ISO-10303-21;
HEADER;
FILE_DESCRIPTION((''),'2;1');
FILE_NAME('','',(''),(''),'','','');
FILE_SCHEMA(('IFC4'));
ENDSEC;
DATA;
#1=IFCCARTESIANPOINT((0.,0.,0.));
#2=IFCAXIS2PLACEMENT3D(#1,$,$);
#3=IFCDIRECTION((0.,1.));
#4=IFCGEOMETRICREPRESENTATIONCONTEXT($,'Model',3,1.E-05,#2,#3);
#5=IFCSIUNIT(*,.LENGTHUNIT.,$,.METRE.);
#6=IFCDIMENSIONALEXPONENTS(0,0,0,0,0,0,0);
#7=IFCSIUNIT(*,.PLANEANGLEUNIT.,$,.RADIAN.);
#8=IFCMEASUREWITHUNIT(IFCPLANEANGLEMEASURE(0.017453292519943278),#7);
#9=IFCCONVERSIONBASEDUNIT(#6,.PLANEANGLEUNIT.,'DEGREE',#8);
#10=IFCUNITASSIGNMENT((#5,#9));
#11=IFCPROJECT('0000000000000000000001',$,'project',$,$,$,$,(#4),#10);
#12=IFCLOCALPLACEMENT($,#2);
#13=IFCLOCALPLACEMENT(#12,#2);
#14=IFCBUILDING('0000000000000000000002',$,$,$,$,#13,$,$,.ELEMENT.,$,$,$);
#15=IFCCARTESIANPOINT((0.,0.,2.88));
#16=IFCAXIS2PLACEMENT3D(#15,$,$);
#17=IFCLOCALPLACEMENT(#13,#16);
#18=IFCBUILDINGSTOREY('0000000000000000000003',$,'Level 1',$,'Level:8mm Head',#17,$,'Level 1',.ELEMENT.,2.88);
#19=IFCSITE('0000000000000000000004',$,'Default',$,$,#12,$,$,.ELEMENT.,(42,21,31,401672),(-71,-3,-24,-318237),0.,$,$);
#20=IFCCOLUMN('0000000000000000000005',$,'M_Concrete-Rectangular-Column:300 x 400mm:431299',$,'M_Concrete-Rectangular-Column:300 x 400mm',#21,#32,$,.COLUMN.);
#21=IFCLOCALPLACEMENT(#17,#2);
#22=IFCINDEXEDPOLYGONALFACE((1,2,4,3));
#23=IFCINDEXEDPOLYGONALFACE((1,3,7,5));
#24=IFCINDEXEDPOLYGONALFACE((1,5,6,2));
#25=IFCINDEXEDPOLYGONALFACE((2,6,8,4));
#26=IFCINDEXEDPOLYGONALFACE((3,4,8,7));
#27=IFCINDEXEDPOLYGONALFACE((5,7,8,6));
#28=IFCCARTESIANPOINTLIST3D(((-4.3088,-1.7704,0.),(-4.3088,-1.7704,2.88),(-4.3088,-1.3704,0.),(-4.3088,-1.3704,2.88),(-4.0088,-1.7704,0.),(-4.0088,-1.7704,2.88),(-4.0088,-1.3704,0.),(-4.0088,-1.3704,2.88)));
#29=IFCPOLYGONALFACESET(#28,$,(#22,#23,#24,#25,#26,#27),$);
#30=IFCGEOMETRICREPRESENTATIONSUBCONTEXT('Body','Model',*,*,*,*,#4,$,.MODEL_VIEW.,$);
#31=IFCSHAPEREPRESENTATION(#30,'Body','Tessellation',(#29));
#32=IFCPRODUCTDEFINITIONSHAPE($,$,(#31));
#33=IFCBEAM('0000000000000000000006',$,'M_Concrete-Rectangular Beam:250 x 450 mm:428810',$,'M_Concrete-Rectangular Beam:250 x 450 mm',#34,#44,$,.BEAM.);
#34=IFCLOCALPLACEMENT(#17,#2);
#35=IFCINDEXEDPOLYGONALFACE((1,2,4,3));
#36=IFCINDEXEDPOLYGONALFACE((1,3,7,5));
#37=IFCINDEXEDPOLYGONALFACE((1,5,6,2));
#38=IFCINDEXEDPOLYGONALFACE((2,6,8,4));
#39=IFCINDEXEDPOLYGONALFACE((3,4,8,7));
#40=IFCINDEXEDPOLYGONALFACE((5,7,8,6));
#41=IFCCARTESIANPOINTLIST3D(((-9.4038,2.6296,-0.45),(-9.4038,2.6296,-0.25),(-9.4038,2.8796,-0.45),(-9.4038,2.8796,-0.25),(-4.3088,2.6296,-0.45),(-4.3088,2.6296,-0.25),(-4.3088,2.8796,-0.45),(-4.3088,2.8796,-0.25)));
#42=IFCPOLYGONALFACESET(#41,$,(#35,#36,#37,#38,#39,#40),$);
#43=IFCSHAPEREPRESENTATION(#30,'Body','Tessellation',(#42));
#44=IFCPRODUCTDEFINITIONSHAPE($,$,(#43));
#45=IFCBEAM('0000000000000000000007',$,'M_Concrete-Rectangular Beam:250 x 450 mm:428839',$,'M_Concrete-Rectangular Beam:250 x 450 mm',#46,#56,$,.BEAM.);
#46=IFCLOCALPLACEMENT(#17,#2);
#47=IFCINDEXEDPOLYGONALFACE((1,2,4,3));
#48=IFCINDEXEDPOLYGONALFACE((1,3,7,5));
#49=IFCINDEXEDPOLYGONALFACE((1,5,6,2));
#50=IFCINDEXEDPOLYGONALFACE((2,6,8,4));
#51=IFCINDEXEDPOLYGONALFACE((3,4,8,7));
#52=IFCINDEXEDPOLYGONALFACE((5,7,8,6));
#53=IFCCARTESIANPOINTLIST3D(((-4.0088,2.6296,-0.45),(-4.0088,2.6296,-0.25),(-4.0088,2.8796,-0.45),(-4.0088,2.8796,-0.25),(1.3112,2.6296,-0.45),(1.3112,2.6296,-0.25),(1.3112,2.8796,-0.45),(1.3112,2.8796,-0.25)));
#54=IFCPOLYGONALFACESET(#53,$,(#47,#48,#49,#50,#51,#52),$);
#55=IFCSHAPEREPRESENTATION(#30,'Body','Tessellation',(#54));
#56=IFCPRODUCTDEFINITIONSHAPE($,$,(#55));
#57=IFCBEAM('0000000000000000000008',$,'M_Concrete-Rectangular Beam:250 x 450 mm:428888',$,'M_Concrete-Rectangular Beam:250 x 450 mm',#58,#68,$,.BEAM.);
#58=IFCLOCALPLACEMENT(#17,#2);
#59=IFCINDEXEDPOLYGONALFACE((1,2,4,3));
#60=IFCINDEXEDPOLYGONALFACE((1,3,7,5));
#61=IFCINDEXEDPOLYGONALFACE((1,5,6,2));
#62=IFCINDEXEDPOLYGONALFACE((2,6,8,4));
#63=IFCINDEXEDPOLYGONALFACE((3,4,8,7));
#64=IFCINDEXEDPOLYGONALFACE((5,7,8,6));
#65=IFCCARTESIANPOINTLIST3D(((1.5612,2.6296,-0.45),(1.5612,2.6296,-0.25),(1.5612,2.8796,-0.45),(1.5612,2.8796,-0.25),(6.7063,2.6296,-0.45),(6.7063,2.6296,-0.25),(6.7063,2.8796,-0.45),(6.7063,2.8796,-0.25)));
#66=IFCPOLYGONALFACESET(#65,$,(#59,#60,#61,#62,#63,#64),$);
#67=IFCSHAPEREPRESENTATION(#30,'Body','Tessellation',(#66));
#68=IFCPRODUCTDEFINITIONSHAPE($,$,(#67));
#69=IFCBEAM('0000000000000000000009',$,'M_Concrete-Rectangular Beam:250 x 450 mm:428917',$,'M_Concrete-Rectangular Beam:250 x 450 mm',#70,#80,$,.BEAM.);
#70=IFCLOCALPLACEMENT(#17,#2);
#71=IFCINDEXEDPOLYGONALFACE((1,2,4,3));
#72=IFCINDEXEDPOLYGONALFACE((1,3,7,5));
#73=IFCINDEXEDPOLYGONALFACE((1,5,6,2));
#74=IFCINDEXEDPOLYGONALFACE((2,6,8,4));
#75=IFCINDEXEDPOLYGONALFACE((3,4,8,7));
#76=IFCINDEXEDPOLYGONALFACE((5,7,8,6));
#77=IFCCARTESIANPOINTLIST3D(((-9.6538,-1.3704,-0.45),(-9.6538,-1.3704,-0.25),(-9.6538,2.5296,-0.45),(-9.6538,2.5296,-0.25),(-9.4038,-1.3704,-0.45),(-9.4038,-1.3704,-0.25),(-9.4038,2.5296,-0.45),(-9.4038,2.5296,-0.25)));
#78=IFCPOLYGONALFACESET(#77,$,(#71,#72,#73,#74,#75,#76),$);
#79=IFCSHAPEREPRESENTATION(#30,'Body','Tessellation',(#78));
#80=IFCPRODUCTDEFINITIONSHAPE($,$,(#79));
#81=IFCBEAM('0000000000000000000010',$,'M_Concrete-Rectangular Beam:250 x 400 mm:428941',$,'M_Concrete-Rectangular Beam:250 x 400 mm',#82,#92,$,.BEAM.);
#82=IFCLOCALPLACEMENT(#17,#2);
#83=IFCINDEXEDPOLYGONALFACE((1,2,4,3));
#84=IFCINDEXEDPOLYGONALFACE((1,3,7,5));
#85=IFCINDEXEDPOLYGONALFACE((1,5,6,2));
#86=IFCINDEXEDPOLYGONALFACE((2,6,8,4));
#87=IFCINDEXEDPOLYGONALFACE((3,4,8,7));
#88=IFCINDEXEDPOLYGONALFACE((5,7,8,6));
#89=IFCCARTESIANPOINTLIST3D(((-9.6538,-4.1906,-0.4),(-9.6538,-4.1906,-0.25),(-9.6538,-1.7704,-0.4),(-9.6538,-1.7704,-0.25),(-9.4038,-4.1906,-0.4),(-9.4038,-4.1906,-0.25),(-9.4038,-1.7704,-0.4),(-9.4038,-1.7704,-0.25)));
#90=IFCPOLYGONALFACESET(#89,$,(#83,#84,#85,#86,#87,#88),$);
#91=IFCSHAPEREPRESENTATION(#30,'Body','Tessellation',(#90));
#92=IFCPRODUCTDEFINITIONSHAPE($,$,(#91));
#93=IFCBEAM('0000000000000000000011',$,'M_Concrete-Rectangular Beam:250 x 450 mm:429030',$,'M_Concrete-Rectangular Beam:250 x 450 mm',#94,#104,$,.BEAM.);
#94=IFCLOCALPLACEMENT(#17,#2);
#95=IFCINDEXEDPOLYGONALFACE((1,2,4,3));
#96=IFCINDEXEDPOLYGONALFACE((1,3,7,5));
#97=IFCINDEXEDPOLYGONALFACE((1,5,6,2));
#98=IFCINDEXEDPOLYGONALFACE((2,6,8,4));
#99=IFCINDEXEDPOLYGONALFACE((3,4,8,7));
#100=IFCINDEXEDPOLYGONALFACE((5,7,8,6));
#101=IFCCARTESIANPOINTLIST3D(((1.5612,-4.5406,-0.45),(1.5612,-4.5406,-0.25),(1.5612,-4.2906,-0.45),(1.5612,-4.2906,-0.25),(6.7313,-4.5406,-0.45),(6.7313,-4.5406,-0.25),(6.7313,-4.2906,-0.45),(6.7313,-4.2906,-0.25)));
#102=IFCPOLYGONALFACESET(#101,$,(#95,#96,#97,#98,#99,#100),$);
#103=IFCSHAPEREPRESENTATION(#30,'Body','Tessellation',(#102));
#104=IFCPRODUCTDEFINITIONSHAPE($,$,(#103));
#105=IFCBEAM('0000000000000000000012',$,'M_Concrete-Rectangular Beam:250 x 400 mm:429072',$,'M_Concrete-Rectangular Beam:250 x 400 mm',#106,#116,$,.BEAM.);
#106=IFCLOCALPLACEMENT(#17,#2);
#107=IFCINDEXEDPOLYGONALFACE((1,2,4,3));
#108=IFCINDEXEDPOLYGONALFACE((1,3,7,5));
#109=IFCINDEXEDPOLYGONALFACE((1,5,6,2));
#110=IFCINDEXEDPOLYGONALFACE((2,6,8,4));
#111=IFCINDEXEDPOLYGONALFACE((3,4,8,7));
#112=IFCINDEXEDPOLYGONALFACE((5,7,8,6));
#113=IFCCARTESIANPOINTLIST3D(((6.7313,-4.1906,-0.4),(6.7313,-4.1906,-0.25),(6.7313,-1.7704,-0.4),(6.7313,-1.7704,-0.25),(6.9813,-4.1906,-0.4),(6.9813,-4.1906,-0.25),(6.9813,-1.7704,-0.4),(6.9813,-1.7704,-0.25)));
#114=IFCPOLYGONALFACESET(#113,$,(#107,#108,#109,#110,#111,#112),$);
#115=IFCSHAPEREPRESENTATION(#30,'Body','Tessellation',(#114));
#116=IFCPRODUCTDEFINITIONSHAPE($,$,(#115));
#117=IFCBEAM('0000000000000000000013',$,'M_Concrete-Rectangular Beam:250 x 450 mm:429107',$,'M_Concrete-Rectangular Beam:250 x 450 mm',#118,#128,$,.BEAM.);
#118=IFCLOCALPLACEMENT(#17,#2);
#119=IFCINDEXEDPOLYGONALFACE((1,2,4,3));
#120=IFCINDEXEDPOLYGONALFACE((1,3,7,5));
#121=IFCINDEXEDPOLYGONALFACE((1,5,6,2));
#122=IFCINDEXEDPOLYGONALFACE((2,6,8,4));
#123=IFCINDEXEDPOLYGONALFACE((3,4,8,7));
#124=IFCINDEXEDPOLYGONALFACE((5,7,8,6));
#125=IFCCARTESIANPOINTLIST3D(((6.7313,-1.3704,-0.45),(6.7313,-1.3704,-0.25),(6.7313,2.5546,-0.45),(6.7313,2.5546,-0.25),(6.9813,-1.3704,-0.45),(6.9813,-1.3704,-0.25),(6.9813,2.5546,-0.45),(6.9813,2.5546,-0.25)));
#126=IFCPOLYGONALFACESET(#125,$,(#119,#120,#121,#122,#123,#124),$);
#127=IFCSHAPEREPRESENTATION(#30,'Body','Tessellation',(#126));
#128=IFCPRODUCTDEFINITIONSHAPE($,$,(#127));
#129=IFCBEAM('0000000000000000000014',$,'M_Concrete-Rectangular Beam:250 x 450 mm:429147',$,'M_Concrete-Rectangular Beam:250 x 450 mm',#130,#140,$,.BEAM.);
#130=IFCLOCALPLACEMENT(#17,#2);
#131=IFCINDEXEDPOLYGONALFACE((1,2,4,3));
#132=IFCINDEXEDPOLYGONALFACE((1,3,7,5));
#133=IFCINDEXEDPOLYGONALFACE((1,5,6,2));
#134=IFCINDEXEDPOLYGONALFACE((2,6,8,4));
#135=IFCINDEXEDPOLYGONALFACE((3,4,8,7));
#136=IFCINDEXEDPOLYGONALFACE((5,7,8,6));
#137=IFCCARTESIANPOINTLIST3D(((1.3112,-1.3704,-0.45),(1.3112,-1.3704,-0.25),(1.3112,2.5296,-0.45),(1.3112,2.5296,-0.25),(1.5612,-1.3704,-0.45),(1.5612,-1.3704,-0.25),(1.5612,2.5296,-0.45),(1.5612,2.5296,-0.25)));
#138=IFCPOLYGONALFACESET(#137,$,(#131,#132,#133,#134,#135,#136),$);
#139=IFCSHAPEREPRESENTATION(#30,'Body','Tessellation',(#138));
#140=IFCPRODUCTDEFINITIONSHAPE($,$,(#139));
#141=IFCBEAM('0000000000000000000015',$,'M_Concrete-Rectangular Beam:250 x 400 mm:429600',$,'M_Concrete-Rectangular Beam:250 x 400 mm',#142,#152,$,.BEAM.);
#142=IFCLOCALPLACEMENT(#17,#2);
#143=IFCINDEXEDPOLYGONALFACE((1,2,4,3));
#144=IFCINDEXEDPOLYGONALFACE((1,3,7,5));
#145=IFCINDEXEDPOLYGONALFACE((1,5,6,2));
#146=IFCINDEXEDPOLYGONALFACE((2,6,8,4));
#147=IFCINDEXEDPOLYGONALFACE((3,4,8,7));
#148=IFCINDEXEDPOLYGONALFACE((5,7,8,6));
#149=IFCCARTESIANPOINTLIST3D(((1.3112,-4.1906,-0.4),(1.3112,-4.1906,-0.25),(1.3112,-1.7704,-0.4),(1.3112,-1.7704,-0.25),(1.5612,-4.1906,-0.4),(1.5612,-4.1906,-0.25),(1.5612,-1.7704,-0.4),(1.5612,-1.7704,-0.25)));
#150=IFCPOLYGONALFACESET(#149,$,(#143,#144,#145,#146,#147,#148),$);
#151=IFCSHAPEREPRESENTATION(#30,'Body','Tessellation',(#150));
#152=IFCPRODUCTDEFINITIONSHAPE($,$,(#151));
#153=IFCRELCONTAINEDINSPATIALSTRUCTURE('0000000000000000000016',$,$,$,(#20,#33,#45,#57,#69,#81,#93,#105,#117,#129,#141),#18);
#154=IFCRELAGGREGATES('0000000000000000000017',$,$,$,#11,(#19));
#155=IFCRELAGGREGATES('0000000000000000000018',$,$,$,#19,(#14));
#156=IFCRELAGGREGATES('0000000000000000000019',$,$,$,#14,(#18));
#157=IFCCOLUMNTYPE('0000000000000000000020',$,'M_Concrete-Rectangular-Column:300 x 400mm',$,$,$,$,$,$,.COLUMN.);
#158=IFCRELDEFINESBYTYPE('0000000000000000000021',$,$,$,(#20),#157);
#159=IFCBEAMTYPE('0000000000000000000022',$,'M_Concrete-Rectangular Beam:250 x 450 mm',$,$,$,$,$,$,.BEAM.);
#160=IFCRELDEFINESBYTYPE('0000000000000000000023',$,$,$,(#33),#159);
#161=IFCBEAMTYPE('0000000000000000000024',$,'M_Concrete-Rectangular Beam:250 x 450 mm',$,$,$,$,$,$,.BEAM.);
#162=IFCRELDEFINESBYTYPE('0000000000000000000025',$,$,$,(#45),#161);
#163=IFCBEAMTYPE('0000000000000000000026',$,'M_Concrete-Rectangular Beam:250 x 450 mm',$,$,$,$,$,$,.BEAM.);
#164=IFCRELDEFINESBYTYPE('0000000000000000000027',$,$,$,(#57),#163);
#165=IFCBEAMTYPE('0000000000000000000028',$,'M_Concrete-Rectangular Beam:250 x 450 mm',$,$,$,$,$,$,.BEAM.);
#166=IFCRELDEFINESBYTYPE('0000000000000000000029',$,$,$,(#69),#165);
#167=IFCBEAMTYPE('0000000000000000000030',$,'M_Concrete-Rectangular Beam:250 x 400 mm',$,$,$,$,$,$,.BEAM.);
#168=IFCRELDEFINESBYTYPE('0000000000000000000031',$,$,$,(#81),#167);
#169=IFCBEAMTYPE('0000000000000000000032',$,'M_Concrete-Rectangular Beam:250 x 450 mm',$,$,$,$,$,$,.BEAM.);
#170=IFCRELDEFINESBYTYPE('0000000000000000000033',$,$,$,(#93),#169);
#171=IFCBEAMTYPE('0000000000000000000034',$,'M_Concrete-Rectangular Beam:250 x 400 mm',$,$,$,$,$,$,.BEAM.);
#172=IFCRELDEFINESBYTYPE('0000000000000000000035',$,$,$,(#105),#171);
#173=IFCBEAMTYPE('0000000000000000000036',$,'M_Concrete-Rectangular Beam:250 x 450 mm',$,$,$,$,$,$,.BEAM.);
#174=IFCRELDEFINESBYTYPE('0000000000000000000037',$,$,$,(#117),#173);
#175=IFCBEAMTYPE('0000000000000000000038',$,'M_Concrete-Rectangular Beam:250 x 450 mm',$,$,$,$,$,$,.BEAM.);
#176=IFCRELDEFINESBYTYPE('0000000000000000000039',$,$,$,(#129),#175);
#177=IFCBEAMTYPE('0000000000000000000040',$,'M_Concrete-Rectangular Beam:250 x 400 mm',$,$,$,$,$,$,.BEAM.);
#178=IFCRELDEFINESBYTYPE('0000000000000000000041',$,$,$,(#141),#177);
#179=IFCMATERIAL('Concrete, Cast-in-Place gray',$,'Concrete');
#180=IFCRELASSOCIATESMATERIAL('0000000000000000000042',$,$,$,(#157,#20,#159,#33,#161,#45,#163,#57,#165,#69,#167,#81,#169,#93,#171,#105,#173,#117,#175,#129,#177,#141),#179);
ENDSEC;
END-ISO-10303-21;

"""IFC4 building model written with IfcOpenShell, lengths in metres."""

from ifc_helpers import new_model, entity, si_unit, converted_unit, direction, frame, origin, place, context, subcontext, project, spatial, indexed_curve, outline, extrude, source, transform, mapped, material, type_object, type_shapes, element, save


model = new_model("IFC4")

# Units and contexts
model_context = context("Model", 3, precision=1e-05, world=origin(), true_north=direction((0.0, 1.0)))
body_context = subcontext(model_context, "Body", "Model", "MODEL_VIEW")
ifc_project = project(units=[si_unit("LENGTHUNIT", "METRE"), converted_unit("PLANEANGLEUNIT", "DEGREE", entity("IfcPlaneAngleMeasure", 0.017453292519943278), si_unit("PLANEANGLEUNIT", "RADIAN"), dimensions=[0, 0, 0, 0, 0, 0, 0])], contexts=[model_context])

# Site, building, storey
site_placement = place(None, origin())
site = spatial("IfcSite", under=ifc_project, at=site_placement, Name="Default", CompositionType="ELEMENT", RefLatitude=(42, 21, 31, 401672), RefLongitude=(-71, -3, -24, -318237), RefElevation=0.0)
building_placement = place(site_placement, origin())
building = spatial("IfcBuilding", under=site, at=building_placement, CompositionType="ELEMENT")
storey_placement = place(building_placement, frame((0.0, 0.0, 2.88)))
storey = spatial("IfcBuildingStorey", under=building, at=storey_placement, Name="Level 1", ObjectType="Level:8mm Head", LongName="Level 1", CompositionType="ELEMENT", Elevation=2.88)

# Column
ifc_material = material(Name="Concrete, Cast-in-Place gray", Category="Concrete")
column_type_1 = type_object("IfcColumnType", Name="M_Concrete-Rectangular-Column:300 x 400mm", PredefinedType="COLUMN", material=ifc_material)
shared_shape_1 = source(origin(), body_context, "Body", "SweptSolid", [
    extrude(outline(indexed_curve([(-0.15, -0.2), (0.15, -0.2), (0.15, 0.2), (-0.15, 0.2), (-0.15, -0.2)], self_intersect=False)), frame((-4.1588, -1.5704, 2.88), z_axis=(0.0, 0.0, 1.0), x_axis=(-1.0, 0.0, 0.0)), (0.0, 0.0, 1.0), 2.88),
])
type_shapes(column_type_1, [shared_shape_1])
column_1_placement = place(storey_placement, frame((0.0, 0.0, -2.88)))
element("IfcColumn", 1, at=column_1_placement, inside=storey, type_object=column_type_1, material=ifc_material, Name="M_Concrete-Rectangular-Column:300 x 400mm:431299", ObjectType="M_Concrete-Rectangular-Column:300 x 400mm", PredefinedType="COLUMN", context=body_context, shape_type="MappedRepresentation", body=[
    mapped(shared_shape_1, transform((0.0, 0.0, 0.0), scale=1.0)),
])

# Beams
beam_type_1 = type_object("IfcBeamType", Name="M_Concrete-Rectangular Beam:250 x 450 mm", PredefinedType="BEAM", material=ifc_material)
shared_shape_2 = source(origin(), body_context, "Body", "SweptSolid", [
    extrude(outline(indexed_curve([(-0.1, -0.125), (0.1, -0.125), (0.1, 0.125), (-0.1, 0.125), (-0.1, -0.125)], self_intersect=False)), frame((-9.4038, 2.7546, 2.53), z_axis=(1.0, 0.0, 0.0), x_axis=(0.0, 0.0, -1.0)), (0.0, 0.0, 1.0), 5.095),
])
type_shapes(beam_type_1, [shared_shape_2])
beam_1_placement = place(storey_placement, frame((0.0, 0.0, -2.88)))
element("IfcBeam", 2, at=beam_1_placement, inside=storey, type_object=beam_type_1, material=ifc_material, Name="M_Concrete-Rectangular Beam:250 x 450 mm:428810", ObjectType="M_Concrete-Rectangular Beam:250 x 450 mm", PredefinedType="BEAM", context=body_context, shape_type="MappedRepresentation", body=[
    mapped(shared_shape_2, transform((0.0, 0.0, 0.0), scale=1.0)),
])
beam_type_2 = type_object("IfcBeamType", Name="M_Concrete-Rectangular Beam:250 x 450 mm", PredefinedType="BEAM", material=ifc_material)
shared_shape_3 = source(origin(), body_context, "Body", "SweptSolid", [
    extrude(outline(indexed_curve([(-0.1, -0.125), (0.1, -0.125), (0.1, 0.125), (-0.1, 0.125), (-0.1, -0.125)], self_intersect=False)), frame((-4.0088, 2.7546, 2.53), z_axis=(1.0, 0.0, 0.0), x_axis=(0.0, 0.0, -1.0)), (0.0, 0.0, 1.0), 5.32),
])
type_shapes(beam_type_2, [shared_shape_3])
beam_2_placement = place(storey_placement, frame((0.0, 0.0, -2.88)))
element("IfcBeam", 3, at=beam_2_placement, inside=storey, type_object=beam_type_2, material=ifc_material, Name="M_Concrete-Rectangular Beam:250 x 450 mm:428839", ObjectType="M_Concrete-Rectangular Beam:250 x 450 mm", PredefinedType="BEAM", context=body_context, shape_type="MappedRepresentation", body=[
    mapped(shared_shape_3, transform((0.0, 0.0, 0.0), scale=1.0)),
])
beam_type_3 = type_object("IfcBeamType", Name="M_Concrete-Rectangular Beam:250 x 450 mm", PredefinedType="BEAM", material=ifc_material)
shared_shape_4 = source(origin(), body_context, "Body", "SweptSolid", [
    extrude(outline(indexed_curve([(-0.1, -0.125), (0.1, -0.125), (0.1, 0.125), (-0.1, 0.125), (-0.1, -0.125)], self_intersect=False)), frame((1.5612, 2.7546, 2.53), z_axis=(1.0, 0.0, 0.0), x_axis=(0.0, 0.0, -1.0)), (0.0, 0.0, 1.0), 5.1451),
])
type_shapes(beam_type_3, [shared_shape_4])
beam_3_placement = place(storey_placement, frame((0.0, 0.0, -2.88)))
element("IfcBeam", 4, at=beam_3_placement, inside=storey, type_object=beam_type_3, material=ifc_material, Name="M_Concrete-Rectangular Beam:250 x 450 mm:428888", ObjectType="M_Concrete-Rectangular Beam:250 x 450 mm", PredefinedType="BEAM", context=body_context, shape_type="MappedRepresentation", body=[
    mapped(shared_shape_4, transform((0.0, 0.0, 0.0), scale=1.0)),
])
beam_type_4 = type_object("IfcBeamType", Name="M_Concrete-Rectangular Beam:250 x 450 mm", PredefinedType="BEAM", material=ifc_material)
shared_shape_5 = source(origin(), body_context, "Body", "SweptSolid", [
    extrude(outline(indexed_curve([(-0.125, -0.1), (0.125, -0.1), (0.125, 0.1), (-0.125, 0.1), (-0.125, -0.1)], self_intersect=False)), frame((-9.5288, 2.5296, 2.53), z_axis=(0.0, -1.0, 0.0), x_axis=(-1.0, 0.0, 0.0)), (0.0, 0.0, 1.0), 3.9),
])
type_shapes(beam_type_4, [shared_shape_5])
beam_4_placement = place(storey_placement, frame((0.0, 0.0, -2.88)))
element("IfcBeam", 5, at=beam_4_placement, inside=storey, type_object=beam_type_4, material=ifc_material, Name="M_Concrete-Rectangular Beam:250 x 450 mm:428917", ObjectType="M_Concrete-Rectangular Beam:250 x 450 mm", PredefinedType="BEAM", context=body_context, shape_type="MappedRepresentation", body=[
    mapped(shared_shape_5, transform((0.0, 0.0, 0.0), scale=1.0)),
])
beam_type_5 = type_object("IfcBeamType", Name="M_Concrete-Rectangular Beam:250 x 400 mm", PredefinedType="BEAM", material=ifc_material)
shared_shape_6 = source(origin(), body_context, "Body", "SweptSolid", [
    extrude(outline(indexed_curve([(-0.125, -0.075), (0.125, -0.075), (0.125, 0.075), (-0.125, 0.075), (-0.125, -0.075)], self_intersect=False)), frame((-9.5288, -1.7704, 2.555), z_axis=(0.0, -1.0, 0.0), x_axis=(-1.0, 0.0, 0.0)), (0.0, 0.0, 1.0), 2.4202),
])
type_shapes(beam_type_5, [shared_shape_6])
beam_5_placement = place(storey_placement, frame((0.0, 0.0, -2.88)))
element("IfcBeam", 6, at=beam_5_placement, inside=storey, type_object=beam_type_5, material=ifc_material, Name="M_Concrete-Rectangular Beam:250 x 400 mm:428941", ObjectType="M_Concrete-Rectangular Beam:250 x 400 mm", PredefinedType="BEAM", context=body_context, shape_type="MappedRepresentation", body=[
    mapped(shared_shape_6, transform((0.0, 0.0, 0.0), scale=1.0)),
])
beam_type_6 = type_object("IfcBeamType", Name="M_Concrete-Rectangular Beam:250 x 450 mm", PredefinedType="BEAM", material=ifc_material)
shared_shape_7 = source(origin(), body_context, "Body", "SweptSolid", [
    extrude(outline(indexed_curve([(-0.1, -0.125), (0.1, -0.125), (0.1, 0.125), (-0.1, 0.125), (-0.1, -0.125)], self_intersect=False)), frame((1.5612, -4.4156, 2.53), z_axis=(1.0, 0.0, 0.0), x_axis=(0.0, 0.0, -1.0)), (0.0, 0.0, 1.0), 5.1701),
])
type_shapes(beam_type_6, [shared_shape_7])
beam_6_placement = place(storey_placement, frame((0.0, 0.0, -2.88)))
element("IfcBeam", 7, at=beam_6_placement, inside=storey, type_object=beam_type_6, material=ifc_material, Name="M_Concrete-Rectangular Beam:250 x 450 mm:429030", ObjectType="M_Concrete-Rectangular Beam:250 x 450 mm", PredefinedType="BEAM", context=body_context, shape_type="MappedRepresentation", body=[
    mapped(shared_shape_7, transform((0.0, 0.0, 0.0), scale=1.0)),
])
beam_type_7 = type_object("IfcBeamType", Name="M_Concrete-Rectangular Beam:250 x 400 mm", PredefinedType="BEAM", material=ifc_material)
shared_shape_8 = source(origin(), body_context, "Body", "SweptSolid", [
    extrude(outline(indexed_curve([(-0.125, -0.075), (0.125, -0.075), (0.125, 0.075), (-0.125, 0.075), (-0.125, -0.075)], self_intersect=False)), frame((6.8563, -4.1906, 2.555), z_axis=(0.0, 1.0, 0.0), x_axis=(-1.0, 0.0, 0.0)), (0.0, 0.0, 1.0), 2.4202),
])
type_shapes(beam_type_7, [shared_shape_8])
beam_7_placement = place(storey_placement, frame((0.0, 0.0, -2.88)))
element("IfcBeam", 8, at=beam_7_placement, inside=storey, type_object=beam_type_7, material=ifc_material, Name="M_Concrete-Rectangular Beam:250 x 400 mm:429072", ObjectType="M_Concrete-Rectangular Beam:250 x 400 mm", PredefinedType="BEAM", context=body_context, shape_type="MappedRepresentation", body=[
    mapped(shared_shape_8, transform((0.0, 0.0, 0.0), scale=1.0)),
])
beam_type_8 = type_object("IfcBeamType", Name="M_Concrete-Rectangular Beam:250 x 450 mm", PredefinedType="BEAM", material=ifc_material)
shared_shape_9 = source(origin(), body_context, "Body", "SweptSolid", [
    extrude(outline(indexed_curve([(-0.125, -0.1), (0.125, -0.1), (0.125, 0.1), (-0.125, 0.1), (-0.125, -0.1)], self_intersect=False)), frame((6.8563, -1.3704, 2.53), z_axis=(0.0, 1.0, 0.0), x_axis=(-1.0, 0.0, 0.0)), (0.0, 0.0, 1.0), 3.925),
])
type_shapes(beam_type_8, [shared_shape_9])
beam_8_placement = place(storey_placement, frame((0.0, 0.0, -2.88)))
element("IfcBeam", 9, at=beam_8_placement, inside=storey, type_object=beam_type_8, material=ifc_material, Name="M_Concrete-Rectangular Beam:250 x 450 mm:429107", ObjectType="M_Concrete-Rectangular Beam:250 x 450 mm", PredefinedType="BEAM", context=body_context, shape_type="MappedRepresentation", body=[
    mapped(shared_shape_9, transform((0.0, 0.0, 0.0), scale=1.0)),
])
beam_type_9 = type_object("IfcBeamType", Name="M_Concrete-Rectangular Beam:250 x 450 mm", PredefinedType="BEAM", material=ifc_material)
shared_shape_10 = source(origin(), body_context, "Body", "SweptSolid", [
    extrude(outline(indexed_curve([(-0.125, -0.1), (0.125, -0.1), (0.125, 0.1), (-0.125, 0.1), (-0.125, -0.1)], self_intersect=False)), frame((1.4362, -1.3704, 2.53), z_axis=(0.0, 1.0, 0.0), x_axis=(-1.0, 0.0, 0.0)), (0.0, 0.0, 1.0), 3.9),
])
type_shapes(beam_type_9, [shared_shape_10])
beam_9_placement = place(storey_placement, frame((0.0, 0.0, -2.88)))
element("IfcBeam", 10, at=beam_9_placement, inside=storey, type_object=beam_type_9, material=ifc_material, Name="M_Concrete-Rectangular Beam:250 x 450 mm:429147", ObjectType="M_Concrete-Rectangular Beam:250 x 450 mm", PredefinedType="BEAM", context=body_context, shape_type="MappedRepresentation", body=[
    mapped(shared_shape_10, transform((0.0, 0.0, 0.0), scale=1.0)),
])
beam_type_10 = type_object("IfcBeamType", Name="M_Concrete-Rectangular Beam:250 x 400 mm", PredefinedType="BEAM", material=ifc_material)
shared_shape_11 = source(origin(), body_context, "Body", "SweptSolid", [
    extrude(outline(indexed_curve([(-0.125, -0.075), (0.125, -0.075), (0.125, 0.075), (-0.125, 0.075), (-0.125, -0.075)], self_intersect=False)), frame((1.4362, -1.7704, 2.555), z_axis=(0.0, -1.0, 0.0), x_axis=(-1.0, 0.0, 0.0)), (0.0, 0.0, 1.0), 2.4202),
])
type_shapes(beam_type_10, [shared_shape_11])
beam_10_placement = place(storey_placement, frame((0.0, 0.0, -2.88)))
element("IfcBeam", 11, at=beam_10_placement, inside=storey, type_object=beam_type_10, material=ifc_material, Name="M_Concrete-Rectangular Beam:250 x 400 mm:429600", ObjectType="M_Concrete-Rectangular Beam:250 x 400 mm", PredefinedType="BEAM", context=body_context, shape_type="MappedRepresentation", body=[
    mapped(shared_shape_11, transform((0.0, 0.0, 0.0), scale=1.0)),
])

save(model, "model.ifc")
